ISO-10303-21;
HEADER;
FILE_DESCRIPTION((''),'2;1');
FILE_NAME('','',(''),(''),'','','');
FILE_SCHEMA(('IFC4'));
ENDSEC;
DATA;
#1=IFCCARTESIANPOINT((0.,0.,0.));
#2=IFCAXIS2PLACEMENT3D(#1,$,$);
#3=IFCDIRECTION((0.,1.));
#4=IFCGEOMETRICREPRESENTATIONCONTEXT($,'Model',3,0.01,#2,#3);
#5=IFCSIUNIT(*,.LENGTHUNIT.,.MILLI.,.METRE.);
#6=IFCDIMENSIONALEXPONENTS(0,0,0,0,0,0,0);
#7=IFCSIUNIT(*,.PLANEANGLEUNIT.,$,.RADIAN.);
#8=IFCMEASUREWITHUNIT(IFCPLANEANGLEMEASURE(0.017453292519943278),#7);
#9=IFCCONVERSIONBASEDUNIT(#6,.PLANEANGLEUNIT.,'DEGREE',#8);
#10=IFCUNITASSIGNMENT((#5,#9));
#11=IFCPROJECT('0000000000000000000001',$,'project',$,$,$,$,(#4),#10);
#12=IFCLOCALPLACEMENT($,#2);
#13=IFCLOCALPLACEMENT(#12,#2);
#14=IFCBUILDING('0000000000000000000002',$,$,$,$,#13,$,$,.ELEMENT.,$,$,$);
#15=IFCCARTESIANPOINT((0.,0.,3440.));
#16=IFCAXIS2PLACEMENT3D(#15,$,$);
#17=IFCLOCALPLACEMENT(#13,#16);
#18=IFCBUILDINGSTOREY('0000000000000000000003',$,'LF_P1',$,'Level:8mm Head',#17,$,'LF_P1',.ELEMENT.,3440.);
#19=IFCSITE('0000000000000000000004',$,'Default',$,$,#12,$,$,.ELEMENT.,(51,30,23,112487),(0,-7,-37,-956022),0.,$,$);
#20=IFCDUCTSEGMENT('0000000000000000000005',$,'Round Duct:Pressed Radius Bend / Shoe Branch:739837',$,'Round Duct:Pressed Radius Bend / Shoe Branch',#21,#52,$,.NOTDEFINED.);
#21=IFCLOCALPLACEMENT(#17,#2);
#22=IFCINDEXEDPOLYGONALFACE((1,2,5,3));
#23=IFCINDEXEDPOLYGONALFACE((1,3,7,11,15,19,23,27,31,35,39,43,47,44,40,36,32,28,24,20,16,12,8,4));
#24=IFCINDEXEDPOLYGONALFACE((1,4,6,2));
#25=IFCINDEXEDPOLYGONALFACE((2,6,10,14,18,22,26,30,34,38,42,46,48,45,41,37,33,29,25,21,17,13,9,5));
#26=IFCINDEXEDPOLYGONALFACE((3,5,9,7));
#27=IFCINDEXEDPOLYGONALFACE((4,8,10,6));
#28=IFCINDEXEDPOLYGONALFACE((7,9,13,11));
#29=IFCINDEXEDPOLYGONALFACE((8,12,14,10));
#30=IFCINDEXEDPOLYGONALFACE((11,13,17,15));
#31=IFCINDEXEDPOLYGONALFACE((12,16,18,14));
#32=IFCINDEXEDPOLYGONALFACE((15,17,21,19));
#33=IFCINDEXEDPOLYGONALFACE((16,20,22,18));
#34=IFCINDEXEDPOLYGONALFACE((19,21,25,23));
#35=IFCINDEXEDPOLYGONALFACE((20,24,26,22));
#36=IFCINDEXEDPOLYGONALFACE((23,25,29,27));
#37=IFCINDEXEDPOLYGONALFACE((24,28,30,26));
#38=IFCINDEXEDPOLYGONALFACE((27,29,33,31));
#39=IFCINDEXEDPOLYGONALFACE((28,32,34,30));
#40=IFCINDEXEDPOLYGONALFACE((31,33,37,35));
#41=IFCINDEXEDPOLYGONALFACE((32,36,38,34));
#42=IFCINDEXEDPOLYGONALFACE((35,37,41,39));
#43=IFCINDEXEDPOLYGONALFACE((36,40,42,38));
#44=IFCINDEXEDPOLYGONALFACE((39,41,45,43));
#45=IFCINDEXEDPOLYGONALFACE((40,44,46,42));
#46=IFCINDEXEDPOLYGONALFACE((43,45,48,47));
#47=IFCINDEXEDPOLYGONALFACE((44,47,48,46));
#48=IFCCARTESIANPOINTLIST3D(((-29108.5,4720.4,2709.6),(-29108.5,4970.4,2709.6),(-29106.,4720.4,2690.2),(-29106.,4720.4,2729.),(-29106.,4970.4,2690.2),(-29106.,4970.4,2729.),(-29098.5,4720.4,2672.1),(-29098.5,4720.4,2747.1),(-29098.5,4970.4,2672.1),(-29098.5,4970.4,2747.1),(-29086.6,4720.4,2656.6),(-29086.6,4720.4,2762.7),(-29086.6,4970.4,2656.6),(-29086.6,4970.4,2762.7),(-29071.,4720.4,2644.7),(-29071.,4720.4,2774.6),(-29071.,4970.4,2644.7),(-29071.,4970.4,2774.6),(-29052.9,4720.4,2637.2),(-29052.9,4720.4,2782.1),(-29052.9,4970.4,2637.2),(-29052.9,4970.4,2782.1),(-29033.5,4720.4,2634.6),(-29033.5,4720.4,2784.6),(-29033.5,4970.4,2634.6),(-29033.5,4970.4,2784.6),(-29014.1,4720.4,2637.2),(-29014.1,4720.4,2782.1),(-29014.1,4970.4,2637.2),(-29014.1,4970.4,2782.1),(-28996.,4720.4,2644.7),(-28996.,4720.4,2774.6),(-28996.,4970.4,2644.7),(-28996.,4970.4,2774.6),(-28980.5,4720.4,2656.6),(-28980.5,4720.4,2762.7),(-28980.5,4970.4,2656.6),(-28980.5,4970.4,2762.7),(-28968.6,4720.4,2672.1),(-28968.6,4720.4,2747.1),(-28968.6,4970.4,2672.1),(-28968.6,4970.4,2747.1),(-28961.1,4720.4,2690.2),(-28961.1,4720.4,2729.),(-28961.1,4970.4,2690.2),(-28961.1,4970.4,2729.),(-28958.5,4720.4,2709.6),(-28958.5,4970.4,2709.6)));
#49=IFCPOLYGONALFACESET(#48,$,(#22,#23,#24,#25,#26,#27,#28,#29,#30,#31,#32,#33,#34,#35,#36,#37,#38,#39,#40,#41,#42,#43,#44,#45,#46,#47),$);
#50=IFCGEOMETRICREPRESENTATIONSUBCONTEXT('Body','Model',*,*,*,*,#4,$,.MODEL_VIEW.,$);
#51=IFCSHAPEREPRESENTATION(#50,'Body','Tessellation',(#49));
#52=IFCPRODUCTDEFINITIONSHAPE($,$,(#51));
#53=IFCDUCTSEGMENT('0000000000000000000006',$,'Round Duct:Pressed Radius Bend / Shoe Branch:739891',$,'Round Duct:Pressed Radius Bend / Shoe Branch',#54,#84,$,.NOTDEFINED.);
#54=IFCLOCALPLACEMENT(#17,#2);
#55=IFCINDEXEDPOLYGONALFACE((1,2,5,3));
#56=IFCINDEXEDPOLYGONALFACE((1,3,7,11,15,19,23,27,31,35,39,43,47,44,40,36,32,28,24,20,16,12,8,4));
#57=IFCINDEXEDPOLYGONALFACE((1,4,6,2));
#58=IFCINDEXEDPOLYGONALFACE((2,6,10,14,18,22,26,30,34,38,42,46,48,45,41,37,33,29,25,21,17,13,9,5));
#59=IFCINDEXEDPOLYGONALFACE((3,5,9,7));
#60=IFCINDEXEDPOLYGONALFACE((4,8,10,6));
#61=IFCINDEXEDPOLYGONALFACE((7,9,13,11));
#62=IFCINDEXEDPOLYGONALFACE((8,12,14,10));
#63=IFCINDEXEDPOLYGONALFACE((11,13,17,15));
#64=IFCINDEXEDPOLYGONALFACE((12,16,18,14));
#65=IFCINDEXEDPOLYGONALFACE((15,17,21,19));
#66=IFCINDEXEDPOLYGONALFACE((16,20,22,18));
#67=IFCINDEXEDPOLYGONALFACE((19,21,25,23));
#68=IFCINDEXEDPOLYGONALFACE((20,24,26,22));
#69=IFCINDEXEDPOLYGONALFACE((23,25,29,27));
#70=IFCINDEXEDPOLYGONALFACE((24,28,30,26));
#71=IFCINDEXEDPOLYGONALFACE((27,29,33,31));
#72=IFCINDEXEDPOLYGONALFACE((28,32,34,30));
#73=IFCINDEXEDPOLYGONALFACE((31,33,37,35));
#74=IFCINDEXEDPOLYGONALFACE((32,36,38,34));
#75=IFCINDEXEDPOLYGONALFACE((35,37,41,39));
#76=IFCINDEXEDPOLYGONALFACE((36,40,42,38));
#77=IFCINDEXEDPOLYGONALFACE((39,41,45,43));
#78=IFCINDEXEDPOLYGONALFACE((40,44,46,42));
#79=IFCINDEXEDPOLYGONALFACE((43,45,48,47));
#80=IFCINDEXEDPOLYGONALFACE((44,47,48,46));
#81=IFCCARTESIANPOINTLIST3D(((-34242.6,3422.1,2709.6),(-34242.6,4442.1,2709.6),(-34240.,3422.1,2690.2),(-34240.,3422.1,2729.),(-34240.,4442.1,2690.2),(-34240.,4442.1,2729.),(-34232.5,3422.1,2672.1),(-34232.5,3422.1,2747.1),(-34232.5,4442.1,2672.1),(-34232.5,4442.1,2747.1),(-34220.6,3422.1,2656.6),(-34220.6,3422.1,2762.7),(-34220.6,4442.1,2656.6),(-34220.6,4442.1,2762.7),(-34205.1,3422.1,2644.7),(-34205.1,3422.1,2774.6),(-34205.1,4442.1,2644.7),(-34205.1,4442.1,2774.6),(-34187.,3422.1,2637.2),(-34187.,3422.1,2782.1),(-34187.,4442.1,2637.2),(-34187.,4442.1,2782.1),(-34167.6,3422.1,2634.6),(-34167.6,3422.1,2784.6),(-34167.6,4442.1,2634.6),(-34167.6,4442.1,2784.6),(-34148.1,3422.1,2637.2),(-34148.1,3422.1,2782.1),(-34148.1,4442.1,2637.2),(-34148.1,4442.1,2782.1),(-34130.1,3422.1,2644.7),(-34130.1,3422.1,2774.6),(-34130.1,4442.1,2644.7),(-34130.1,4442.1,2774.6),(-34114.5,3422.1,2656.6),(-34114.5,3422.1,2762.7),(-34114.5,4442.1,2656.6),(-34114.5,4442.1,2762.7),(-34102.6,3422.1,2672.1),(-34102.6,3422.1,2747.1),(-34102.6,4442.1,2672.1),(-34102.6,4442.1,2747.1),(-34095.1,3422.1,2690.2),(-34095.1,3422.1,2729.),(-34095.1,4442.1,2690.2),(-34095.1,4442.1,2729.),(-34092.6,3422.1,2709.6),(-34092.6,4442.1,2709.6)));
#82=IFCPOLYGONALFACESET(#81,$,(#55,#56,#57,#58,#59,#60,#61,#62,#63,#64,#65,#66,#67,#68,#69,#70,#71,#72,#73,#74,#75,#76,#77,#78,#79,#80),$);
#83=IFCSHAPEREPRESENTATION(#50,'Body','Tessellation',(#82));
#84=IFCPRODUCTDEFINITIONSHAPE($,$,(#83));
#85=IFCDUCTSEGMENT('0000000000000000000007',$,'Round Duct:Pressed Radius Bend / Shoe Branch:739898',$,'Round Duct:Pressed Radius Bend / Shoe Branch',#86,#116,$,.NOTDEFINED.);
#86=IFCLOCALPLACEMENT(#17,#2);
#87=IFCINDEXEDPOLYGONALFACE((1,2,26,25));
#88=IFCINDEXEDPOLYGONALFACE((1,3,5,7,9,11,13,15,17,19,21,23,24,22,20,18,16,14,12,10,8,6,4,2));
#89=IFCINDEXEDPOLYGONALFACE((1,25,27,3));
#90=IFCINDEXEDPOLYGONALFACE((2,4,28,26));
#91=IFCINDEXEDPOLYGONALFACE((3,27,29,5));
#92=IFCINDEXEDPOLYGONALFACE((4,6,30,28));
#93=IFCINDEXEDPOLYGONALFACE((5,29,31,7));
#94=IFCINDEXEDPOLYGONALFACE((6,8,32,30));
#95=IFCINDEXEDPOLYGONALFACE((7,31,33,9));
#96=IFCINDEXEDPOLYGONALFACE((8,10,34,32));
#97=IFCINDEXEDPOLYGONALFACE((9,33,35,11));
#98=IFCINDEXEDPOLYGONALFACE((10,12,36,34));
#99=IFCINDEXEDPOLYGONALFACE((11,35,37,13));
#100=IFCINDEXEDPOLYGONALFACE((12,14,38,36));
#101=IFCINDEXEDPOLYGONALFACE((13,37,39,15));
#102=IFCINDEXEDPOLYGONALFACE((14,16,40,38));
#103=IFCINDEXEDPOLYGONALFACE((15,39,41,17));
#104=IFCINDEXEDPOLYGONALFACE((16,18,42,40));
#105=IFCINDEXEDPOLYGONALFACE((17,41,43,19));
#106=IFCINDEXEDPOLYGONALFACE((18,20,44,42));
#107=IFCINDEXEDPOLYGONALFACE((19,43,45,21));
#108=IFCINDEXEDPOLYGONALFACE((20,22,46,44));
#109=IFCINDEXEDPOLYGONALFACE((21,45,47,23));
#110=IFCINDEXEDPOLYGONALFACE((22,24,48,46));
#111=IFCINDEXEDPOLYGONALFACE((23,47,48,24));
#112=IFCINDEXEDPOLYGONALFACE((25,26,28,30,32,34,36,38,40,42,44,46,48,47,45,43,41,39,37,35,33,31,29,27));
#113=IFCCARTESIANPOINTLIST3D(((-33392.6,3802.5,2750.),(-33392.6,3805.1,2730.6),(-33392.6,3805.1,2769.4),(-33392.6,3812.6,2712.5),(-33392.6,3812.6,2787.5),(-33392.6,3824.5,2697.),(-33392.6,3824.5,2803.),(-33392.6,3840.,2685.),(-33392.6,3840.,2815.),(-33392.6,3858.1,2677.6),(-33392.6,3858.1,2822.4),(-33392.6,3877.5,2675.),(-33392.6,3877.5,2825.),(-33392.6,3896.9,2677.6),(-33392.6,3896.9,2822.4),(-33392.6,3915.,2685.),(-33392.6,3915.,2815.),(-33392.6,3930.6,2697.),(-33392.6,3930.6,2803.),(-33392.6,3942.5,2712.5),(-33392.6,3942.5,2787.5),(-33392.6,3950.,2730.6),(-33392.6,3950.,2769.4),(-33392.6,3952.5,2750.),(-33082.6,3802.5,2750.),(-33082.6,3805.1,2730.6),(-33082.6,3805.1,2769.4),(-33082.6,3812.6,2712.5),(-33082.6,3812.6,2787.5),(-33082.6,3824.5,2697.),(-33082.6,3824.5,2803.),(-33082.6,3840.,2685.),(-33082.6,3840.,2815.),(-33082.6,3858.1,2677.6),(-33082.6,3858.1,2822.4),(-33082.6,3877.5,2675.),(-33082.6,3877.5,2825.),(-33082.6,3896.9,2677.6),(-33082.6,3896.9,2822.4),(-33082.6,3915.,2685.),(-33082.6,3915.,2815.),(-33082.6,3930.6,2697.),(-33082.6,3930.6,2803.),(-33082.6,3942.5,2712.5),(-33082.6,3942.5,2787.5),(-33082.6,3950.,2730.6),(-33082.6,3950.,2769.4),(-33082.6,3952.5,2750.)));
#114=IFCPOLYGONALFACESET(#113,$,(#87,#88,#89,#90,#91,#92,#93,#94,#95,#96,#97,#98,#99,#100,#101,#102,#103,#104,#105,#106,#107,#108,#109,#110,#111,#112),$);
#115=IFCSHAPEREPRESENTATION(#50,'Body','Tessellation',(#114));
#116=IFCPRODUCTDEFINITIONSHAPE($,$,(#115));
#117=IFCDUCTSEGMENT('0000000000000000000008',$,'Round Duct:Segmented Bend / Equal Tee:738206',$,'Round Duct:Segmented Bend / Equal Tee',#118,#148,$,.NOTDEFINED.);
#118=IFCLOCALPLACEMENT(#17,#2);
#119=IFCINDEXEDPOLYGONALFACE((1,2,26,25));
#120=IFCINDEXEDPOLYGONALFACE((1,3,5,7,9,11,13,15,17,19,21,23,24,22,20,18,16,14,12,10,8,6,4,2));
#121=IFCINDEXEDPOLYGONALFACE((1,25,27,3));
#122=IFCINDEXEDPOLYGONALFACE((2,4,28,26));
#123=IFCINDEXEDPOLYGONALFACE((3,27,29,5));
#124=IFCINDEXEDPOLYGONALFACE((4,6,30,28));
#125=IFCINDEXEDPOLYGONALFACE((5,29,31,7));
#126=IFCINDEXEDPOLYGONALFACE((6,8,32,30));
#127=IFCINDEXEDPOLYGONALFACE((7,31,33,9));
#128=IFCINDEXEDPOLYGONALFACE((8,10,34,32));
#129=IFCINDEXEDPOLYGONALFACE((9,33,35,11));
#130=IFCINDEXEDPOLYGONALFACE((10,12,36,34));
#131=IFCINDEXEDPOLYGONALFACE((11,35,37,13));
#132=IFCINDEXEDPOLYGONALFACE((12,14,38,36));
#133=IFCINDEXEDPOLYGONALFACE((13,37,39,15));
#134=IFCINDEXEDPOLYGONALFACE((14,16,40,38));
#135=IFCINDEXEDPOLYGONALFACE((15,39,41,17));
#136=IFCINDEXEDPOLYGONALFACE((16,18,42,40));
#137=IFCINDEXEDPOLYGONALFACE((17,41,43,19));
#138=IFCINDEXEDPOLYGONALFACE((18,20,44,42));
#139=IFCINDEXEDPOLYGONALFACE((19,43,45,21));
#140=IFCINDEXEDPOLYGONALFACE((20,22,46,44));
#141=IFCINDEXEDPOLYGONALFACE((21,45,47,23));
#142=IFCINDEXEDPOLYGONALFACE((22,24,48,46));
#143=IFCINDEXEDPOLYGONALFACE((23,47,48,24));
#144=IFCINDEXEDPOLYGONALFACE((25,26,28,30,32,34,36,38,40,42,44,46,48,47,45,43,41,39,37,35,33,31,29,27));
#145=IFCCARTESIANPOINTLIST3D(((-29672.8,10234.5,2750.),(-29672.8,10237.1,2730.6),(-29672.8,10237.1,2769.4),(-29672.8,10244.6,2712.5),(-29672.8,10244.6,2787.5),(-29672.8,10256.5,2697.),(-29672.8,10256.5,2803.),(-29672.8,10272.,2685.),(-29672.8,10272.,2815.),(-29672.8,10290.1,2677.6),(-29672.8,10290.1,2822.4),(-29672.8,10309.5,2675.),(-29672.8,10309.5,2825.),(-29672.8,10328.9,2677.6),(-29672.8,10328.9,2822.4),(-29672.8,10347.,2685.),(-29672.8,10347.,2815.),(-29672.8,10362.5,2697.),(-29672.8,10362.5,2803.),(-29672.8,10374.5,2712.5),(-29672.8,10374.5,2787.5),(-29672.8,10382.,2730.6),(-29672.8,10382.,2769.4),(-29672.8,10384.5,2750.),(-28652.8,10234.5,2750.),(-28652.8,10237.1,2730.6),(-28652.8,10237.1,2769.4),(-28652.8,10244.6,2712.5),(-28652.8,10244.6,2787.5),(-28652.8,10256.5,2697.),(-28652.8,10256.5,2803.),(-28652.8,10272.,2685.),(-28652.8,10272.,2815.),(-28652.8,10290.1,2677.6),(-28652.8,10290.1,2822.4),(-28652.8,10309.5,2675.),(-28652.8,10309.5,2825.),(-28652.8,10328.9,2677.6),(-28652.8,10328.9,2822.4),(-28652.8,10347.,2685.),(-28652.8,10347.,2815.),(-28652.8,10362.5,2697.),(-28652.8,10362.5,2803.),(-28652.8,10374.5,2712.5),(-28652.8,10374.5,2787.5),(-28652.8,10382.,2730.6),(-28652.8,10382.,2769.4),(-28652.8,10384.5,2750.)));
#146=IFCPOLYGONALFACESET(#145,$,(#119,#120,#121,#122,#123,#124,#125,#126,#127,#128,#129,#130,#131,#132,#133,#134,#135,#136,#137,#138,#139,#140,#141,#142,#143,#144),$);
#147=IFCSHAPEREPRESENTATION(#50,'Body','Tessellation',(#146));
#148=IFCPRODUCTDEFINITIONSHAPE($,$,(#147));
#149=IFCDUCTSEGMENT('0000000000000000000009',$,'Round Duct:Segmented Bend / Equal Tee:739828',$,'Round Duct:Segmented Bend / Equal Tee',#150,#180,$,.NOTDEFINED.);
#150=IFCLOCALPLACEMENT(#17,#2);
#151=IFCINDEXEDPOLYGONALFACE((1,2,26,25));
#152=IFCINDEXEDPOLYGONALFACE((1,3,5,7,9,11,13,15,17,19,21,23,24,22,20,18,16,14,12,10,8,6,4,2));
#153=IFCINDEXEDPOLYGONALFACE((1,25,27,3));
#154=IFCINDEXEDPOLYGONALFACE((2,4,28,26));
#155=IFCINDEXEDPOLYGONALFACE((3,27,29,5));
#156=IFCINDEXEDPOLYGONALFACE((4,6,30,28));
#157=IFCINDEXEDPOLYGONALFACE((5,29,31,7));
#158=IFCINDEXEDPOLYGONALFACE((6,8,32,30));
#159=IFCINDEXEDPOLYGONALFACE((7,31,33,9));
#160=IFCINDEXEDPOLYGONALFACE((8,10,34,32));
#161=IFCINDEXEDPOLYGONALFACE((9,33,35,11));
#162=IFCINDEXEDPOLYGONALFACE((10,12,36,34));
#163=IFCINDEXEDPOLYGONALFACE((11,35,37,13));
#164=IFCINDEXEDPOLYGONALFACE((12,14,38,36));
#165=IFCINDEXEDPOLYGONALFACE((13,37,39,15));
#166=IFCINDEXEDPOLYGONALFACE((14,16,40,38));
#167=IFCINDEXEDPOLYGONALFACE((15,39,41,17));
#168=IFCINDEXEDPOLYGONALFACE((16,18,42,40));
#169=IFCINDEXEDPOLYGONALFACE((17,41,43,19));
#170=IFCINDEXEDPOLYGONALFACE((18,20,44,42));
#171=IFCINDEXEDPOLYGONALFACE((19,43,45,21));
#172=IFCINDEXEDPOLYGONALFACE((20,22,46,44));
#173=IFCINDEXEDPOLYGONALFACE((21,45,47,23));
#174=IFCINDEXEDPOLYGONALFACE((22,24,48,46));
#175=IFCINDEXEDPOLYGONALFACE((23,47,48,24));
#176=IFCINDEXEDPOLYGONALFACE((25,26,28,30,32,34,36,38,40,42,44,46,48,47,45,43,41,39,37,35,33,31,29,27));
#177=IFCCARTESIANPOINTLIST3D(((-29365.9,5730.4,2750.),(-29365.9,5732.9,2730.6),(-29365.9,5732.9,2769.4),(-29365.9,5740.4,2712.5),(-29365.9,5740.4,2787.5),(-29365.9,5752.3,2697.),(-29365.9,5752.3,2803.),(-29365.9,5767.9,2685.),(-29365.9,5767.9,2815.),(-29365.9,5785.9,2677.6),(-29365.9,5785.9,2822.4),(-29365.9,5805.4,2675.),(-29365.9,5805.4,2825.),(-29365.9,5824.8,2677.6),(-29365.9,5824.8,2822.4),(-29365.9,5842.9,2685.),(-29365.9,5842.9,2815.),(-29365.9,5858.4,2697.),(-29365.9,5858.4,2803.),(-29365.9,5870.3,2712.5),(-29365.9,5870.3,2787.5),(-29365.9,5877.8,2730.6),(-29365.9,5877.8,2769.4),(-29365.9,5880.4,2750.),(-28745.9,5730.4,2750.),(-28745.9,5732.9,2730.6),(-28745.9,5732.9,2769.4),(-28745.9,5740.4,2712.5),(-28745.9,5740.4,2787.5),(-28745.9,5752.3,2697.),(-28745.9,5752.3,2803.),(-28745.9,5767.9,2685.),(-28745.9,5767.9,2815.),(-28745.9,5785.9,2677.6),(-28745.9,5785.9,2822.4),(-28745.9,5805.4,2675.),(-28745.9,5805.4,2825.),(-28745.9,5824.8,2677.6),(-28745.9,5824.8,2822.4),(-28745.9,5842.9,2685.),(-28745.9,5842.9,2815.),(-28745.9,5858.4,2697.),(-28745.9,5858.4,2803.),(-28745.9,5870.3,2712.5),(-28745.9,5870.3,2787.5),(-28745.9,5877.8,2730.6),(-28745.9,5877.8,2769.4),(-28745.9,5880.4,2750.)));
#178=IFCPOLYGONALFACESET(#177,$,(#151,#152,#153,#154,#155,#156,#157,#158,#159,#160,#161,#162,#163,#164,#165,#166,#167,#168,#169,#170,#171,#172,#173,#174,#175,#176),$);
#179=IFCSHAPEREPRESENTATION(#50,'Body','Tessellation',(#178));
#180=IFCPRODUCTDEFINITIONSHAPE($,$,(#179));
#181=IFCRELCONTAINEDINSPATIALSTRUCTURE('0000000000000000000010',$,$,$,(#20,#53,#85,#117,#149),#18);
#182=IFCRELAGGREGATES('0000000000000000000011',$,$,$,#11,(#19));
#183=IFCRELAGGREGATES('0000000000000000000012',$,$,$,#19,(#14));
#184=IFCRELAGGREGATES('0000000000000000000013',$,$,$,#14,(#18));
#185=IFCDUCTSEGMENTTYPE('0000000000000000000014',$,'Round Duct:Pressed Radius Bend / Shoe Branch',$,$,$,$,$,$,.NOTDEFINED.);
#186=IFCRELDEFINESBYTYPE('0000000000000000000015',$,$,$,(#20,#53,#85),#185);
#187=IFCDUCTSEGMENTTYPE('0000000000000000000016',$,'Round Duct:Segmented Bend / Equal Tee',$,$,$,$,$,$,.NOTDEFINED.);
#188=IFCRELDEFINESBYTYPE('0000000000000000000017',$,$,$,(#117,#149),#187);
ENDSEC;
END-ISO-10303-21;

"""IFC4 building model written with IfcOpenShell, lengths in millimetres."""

from ifc_helpers import new_model, entity, si_unit, converted_unit, direction, frame, origin, place, context, subcontext, project, spatial, arc, indexed_curve, outline, extrude, type_object, element, save


model = new_model("IFC4")

# Units and contexts
model_context = context("Model", 3, precision=0.01, world=origin(), true_north=direction((0.0, 1.0)))
body_context = subcontext(model_context, "Body", "Model", "MODEL_VIEW")
ifc_project = project(units=[si_unit("LENGTHUNIT", "METRE", prefix="MILLI"), converted_unit("PLANEANGLEUNIT", "DEGREE", entity("IfcPlaneAngleMeasure", 0.017453292519943278), si_unit("PLANEANGLEUNIT", "RADIAN"), dimensions=[0, 0, 0, 0, 0, 0, 0])], contexts=[model_context])

# Site, building, storey
site_placement = place(None, origin())
site = spatial("IfcSite", under=ifc_project, at=site_placement, Name="Default", CompositionType="ELEMENT", RefLatitude=(51, 30, 23, 112487), RefLongitude=(0, -7, -37, -956022), RefElevation=0.0)
building_placement = place(site_placement, origin())
building = spatial("IfcBuilding", under=site, at=building_placement, CompositionType="ELEMENT")
storey_placement = place(building_placement, frame((0.0, 0.0, 3440.0)))
storey = spatial("IfcBuildingStorey", under=building, at=storey_placement, Name="LF_P1", ObjectType="Level:8mm Head", LongName="LF_P1", CompositionType="ELEMENT", Elevation=3440.0)

# Duct segments
duct_segment_type_1 = type_object("IfcDuctSegmentType", Name="Round Duct:Pressed Radius Bend / Shoe Branch", PredefinedType="NOTDEFINED")
duct_segment_1_placement = place(storey_placement, origin())
element("IfcDuctSegment", 1, at=duct_segment_1_placement, inside=storey, type_object=duct_segment_type_1, Name="Round Duct:Pressed Radius Bend / Shoe Branch:739837", ObjectType="Round Duct:Pressed Radius Bend / Shoe Branch", PredefinedType="NOTDEFINED", context=body_context, shape_type="SweptSolid", body=[
    extrude(outline(indexed_curve([(75.0, 0.0), (53.0, 53.0), (0.0, 75.0), (-53.0, 53.0), (-75.0, 0.0), (-53.0, -53.0), (0.0, -75.0), (53.0, -53.0)], segments=[arc(1, 2, 3), arc(3, 4, 5), arc(5, 6, 7), arc(7, 8, 1)], self_intersect=False)), frame((-29033.5, 4720.4, 2709.6), z_axis=(0.0, 1.0, 0.0), x_axis=(1.0, 0.0, 0.0)), (0.0, 0.0, 1.0), 250.0),
])
duct_segment_2_placement = place(storey_placement, origin())
element("IfcDuctSegment", 2, at=duct_segment_2_placement, inside=storey, type_object=duct_segment_type_1, Name="Round Duct:Pressed Radius Bend / Shoe Branch:739891", ObjectType="Round Duct:Pressed Radius Bend / Shoe Branch", PredefinedType="NOTDEFINED", context=body_context, shape_type="SweptSolid", body=[
    extrude(outline(indexed_curve([(75.0, 0.0), (53.0, 53.0), (0.0, 75.0), (-53.0, 53.0), (-75.0, 0.0), (-53.0, -53.0), (0.0, -75.0), (53.0, -53.0)], segments=[arc(1, 2, 3), arc(3, 4, 5), arc(5, 6, 7), arc(7, 8, 1)], self_intersect=False)), frame((-34167.6, 3422.1, 2709.6), z_axis=(0.0, 1.0, 0.0), x_axis=(1.0, 0.0, 0.0)), (0.0, 0.0, 1.0), 1020.0),
])
duct_segment_3_placement = place(storey_placement, origin())
element("IfcDuctSegment", 3, at=duct_segment_3_placement, inside=storey, type_object=duct_segment_type_1, Name="Round Duct:Pressed Radius Bend / Shoe Branch:739898", ObjectType="Round Duct:Pressed Radius Bend / Shoe Branch", PredefinedType="NOTDEFINED", context=body_context, shape_type="SweptSolid", body=[
    extrude(outline(indexed_curve([(75.0, 0.0), (53.0, 53.0), (0.0, 75.0), (-53.0, 53.0), (-75.0, 0.0), (-53.0, -53.0), (0.0, -75.0), (53.0, -53.0)], segments=[arc(1, 2, 3), arc(3, 4, 5), arc(5, 6, 7), arc(7, 8, 1)], self_intersect=False)), frame((-33392.6, 3877.5, 2750.0), z_axis=(1.0, 0.0, 0.0), x_axis=(0.0, 1.0, 0.0)), (0.0, 0.0, 1.0), 310.0),
])
duct_segment_type_2 = type_object("IfcDuctSegmentType", Name="Round Duct:Segmented Bend / Equal Tee", PredefinedType="NOTDEFINED")
duct_segment_4_placement = place(storey_placement, origin())
element("IfcDuctSegment", 4, at=duct_segment_4_placement, inside=storey, type_object=duct_segment_type_2, Name="Round Duct:Segmented Bend / Equal Tee:738206", ObjectType="Round Duct:Segmented Bend / Equal Tee", PredefinedType="NOTDEFINED", context=body_context, shape_type="SweptSolid", body=[
    extrude(outline(indexed_curve([(75.0, 0.0), (53.0, 53.0), (0.0, 75.0), (-53.0, 53.0), (-75.0, 0.0), (-53.0, -53.0), (0.0, -75.0), (53.0, -53.0)], segments=[arc(1, 2, 3), arc(3, 4, 5), arc(5, 6, 7), arc(7, 8, 1)], self_intersect=False)), frame((-29672.8, 10309.5, 2750.0), z_axis=(1.0, 0.0, 0.0), x_axis=(0.0, -1.0, 0.0)), (0.0, 0.0, 1.0), 1020.0),
])
duct_segment_5_placement = place(storey_placement, origin())
element("IfcDuctSegment", 5, at=duct_segment_5_placement, inside=storey, type_object=duct_segment_type_2, Name="Round Duct:Segmented Bend / Equal Tee:739828", ObjectType="Round Duct:Segmented Bend / Equal Tee", PredefinedType="NOTDEFINED", context=body_context, shape_type="SweptSolid", body=[
    extrude(outline(indexed_curve([(75.0, 0.0), (53.0, 53.0), (0.0, 75.0), (-53.0, 53.0), (-75.0, 0.0), (-53.0, -53.0), (0.0, -75.0), (53.0, -53.0)], segments=[arc(1, 2, 3), arc(3, 4, 5), arc(5, 6, 7), arc(7, 8, 1)], self_intersect=False)), frame((-29365.9, 5805.4, 2750.0), z_axis=(1.0, 0.0, 0.0), x_axis=(0.0, -1.0, 0.0)), (0.0, 0.0, 1.0), 620.0),
])

save(model, "model.ifc")
